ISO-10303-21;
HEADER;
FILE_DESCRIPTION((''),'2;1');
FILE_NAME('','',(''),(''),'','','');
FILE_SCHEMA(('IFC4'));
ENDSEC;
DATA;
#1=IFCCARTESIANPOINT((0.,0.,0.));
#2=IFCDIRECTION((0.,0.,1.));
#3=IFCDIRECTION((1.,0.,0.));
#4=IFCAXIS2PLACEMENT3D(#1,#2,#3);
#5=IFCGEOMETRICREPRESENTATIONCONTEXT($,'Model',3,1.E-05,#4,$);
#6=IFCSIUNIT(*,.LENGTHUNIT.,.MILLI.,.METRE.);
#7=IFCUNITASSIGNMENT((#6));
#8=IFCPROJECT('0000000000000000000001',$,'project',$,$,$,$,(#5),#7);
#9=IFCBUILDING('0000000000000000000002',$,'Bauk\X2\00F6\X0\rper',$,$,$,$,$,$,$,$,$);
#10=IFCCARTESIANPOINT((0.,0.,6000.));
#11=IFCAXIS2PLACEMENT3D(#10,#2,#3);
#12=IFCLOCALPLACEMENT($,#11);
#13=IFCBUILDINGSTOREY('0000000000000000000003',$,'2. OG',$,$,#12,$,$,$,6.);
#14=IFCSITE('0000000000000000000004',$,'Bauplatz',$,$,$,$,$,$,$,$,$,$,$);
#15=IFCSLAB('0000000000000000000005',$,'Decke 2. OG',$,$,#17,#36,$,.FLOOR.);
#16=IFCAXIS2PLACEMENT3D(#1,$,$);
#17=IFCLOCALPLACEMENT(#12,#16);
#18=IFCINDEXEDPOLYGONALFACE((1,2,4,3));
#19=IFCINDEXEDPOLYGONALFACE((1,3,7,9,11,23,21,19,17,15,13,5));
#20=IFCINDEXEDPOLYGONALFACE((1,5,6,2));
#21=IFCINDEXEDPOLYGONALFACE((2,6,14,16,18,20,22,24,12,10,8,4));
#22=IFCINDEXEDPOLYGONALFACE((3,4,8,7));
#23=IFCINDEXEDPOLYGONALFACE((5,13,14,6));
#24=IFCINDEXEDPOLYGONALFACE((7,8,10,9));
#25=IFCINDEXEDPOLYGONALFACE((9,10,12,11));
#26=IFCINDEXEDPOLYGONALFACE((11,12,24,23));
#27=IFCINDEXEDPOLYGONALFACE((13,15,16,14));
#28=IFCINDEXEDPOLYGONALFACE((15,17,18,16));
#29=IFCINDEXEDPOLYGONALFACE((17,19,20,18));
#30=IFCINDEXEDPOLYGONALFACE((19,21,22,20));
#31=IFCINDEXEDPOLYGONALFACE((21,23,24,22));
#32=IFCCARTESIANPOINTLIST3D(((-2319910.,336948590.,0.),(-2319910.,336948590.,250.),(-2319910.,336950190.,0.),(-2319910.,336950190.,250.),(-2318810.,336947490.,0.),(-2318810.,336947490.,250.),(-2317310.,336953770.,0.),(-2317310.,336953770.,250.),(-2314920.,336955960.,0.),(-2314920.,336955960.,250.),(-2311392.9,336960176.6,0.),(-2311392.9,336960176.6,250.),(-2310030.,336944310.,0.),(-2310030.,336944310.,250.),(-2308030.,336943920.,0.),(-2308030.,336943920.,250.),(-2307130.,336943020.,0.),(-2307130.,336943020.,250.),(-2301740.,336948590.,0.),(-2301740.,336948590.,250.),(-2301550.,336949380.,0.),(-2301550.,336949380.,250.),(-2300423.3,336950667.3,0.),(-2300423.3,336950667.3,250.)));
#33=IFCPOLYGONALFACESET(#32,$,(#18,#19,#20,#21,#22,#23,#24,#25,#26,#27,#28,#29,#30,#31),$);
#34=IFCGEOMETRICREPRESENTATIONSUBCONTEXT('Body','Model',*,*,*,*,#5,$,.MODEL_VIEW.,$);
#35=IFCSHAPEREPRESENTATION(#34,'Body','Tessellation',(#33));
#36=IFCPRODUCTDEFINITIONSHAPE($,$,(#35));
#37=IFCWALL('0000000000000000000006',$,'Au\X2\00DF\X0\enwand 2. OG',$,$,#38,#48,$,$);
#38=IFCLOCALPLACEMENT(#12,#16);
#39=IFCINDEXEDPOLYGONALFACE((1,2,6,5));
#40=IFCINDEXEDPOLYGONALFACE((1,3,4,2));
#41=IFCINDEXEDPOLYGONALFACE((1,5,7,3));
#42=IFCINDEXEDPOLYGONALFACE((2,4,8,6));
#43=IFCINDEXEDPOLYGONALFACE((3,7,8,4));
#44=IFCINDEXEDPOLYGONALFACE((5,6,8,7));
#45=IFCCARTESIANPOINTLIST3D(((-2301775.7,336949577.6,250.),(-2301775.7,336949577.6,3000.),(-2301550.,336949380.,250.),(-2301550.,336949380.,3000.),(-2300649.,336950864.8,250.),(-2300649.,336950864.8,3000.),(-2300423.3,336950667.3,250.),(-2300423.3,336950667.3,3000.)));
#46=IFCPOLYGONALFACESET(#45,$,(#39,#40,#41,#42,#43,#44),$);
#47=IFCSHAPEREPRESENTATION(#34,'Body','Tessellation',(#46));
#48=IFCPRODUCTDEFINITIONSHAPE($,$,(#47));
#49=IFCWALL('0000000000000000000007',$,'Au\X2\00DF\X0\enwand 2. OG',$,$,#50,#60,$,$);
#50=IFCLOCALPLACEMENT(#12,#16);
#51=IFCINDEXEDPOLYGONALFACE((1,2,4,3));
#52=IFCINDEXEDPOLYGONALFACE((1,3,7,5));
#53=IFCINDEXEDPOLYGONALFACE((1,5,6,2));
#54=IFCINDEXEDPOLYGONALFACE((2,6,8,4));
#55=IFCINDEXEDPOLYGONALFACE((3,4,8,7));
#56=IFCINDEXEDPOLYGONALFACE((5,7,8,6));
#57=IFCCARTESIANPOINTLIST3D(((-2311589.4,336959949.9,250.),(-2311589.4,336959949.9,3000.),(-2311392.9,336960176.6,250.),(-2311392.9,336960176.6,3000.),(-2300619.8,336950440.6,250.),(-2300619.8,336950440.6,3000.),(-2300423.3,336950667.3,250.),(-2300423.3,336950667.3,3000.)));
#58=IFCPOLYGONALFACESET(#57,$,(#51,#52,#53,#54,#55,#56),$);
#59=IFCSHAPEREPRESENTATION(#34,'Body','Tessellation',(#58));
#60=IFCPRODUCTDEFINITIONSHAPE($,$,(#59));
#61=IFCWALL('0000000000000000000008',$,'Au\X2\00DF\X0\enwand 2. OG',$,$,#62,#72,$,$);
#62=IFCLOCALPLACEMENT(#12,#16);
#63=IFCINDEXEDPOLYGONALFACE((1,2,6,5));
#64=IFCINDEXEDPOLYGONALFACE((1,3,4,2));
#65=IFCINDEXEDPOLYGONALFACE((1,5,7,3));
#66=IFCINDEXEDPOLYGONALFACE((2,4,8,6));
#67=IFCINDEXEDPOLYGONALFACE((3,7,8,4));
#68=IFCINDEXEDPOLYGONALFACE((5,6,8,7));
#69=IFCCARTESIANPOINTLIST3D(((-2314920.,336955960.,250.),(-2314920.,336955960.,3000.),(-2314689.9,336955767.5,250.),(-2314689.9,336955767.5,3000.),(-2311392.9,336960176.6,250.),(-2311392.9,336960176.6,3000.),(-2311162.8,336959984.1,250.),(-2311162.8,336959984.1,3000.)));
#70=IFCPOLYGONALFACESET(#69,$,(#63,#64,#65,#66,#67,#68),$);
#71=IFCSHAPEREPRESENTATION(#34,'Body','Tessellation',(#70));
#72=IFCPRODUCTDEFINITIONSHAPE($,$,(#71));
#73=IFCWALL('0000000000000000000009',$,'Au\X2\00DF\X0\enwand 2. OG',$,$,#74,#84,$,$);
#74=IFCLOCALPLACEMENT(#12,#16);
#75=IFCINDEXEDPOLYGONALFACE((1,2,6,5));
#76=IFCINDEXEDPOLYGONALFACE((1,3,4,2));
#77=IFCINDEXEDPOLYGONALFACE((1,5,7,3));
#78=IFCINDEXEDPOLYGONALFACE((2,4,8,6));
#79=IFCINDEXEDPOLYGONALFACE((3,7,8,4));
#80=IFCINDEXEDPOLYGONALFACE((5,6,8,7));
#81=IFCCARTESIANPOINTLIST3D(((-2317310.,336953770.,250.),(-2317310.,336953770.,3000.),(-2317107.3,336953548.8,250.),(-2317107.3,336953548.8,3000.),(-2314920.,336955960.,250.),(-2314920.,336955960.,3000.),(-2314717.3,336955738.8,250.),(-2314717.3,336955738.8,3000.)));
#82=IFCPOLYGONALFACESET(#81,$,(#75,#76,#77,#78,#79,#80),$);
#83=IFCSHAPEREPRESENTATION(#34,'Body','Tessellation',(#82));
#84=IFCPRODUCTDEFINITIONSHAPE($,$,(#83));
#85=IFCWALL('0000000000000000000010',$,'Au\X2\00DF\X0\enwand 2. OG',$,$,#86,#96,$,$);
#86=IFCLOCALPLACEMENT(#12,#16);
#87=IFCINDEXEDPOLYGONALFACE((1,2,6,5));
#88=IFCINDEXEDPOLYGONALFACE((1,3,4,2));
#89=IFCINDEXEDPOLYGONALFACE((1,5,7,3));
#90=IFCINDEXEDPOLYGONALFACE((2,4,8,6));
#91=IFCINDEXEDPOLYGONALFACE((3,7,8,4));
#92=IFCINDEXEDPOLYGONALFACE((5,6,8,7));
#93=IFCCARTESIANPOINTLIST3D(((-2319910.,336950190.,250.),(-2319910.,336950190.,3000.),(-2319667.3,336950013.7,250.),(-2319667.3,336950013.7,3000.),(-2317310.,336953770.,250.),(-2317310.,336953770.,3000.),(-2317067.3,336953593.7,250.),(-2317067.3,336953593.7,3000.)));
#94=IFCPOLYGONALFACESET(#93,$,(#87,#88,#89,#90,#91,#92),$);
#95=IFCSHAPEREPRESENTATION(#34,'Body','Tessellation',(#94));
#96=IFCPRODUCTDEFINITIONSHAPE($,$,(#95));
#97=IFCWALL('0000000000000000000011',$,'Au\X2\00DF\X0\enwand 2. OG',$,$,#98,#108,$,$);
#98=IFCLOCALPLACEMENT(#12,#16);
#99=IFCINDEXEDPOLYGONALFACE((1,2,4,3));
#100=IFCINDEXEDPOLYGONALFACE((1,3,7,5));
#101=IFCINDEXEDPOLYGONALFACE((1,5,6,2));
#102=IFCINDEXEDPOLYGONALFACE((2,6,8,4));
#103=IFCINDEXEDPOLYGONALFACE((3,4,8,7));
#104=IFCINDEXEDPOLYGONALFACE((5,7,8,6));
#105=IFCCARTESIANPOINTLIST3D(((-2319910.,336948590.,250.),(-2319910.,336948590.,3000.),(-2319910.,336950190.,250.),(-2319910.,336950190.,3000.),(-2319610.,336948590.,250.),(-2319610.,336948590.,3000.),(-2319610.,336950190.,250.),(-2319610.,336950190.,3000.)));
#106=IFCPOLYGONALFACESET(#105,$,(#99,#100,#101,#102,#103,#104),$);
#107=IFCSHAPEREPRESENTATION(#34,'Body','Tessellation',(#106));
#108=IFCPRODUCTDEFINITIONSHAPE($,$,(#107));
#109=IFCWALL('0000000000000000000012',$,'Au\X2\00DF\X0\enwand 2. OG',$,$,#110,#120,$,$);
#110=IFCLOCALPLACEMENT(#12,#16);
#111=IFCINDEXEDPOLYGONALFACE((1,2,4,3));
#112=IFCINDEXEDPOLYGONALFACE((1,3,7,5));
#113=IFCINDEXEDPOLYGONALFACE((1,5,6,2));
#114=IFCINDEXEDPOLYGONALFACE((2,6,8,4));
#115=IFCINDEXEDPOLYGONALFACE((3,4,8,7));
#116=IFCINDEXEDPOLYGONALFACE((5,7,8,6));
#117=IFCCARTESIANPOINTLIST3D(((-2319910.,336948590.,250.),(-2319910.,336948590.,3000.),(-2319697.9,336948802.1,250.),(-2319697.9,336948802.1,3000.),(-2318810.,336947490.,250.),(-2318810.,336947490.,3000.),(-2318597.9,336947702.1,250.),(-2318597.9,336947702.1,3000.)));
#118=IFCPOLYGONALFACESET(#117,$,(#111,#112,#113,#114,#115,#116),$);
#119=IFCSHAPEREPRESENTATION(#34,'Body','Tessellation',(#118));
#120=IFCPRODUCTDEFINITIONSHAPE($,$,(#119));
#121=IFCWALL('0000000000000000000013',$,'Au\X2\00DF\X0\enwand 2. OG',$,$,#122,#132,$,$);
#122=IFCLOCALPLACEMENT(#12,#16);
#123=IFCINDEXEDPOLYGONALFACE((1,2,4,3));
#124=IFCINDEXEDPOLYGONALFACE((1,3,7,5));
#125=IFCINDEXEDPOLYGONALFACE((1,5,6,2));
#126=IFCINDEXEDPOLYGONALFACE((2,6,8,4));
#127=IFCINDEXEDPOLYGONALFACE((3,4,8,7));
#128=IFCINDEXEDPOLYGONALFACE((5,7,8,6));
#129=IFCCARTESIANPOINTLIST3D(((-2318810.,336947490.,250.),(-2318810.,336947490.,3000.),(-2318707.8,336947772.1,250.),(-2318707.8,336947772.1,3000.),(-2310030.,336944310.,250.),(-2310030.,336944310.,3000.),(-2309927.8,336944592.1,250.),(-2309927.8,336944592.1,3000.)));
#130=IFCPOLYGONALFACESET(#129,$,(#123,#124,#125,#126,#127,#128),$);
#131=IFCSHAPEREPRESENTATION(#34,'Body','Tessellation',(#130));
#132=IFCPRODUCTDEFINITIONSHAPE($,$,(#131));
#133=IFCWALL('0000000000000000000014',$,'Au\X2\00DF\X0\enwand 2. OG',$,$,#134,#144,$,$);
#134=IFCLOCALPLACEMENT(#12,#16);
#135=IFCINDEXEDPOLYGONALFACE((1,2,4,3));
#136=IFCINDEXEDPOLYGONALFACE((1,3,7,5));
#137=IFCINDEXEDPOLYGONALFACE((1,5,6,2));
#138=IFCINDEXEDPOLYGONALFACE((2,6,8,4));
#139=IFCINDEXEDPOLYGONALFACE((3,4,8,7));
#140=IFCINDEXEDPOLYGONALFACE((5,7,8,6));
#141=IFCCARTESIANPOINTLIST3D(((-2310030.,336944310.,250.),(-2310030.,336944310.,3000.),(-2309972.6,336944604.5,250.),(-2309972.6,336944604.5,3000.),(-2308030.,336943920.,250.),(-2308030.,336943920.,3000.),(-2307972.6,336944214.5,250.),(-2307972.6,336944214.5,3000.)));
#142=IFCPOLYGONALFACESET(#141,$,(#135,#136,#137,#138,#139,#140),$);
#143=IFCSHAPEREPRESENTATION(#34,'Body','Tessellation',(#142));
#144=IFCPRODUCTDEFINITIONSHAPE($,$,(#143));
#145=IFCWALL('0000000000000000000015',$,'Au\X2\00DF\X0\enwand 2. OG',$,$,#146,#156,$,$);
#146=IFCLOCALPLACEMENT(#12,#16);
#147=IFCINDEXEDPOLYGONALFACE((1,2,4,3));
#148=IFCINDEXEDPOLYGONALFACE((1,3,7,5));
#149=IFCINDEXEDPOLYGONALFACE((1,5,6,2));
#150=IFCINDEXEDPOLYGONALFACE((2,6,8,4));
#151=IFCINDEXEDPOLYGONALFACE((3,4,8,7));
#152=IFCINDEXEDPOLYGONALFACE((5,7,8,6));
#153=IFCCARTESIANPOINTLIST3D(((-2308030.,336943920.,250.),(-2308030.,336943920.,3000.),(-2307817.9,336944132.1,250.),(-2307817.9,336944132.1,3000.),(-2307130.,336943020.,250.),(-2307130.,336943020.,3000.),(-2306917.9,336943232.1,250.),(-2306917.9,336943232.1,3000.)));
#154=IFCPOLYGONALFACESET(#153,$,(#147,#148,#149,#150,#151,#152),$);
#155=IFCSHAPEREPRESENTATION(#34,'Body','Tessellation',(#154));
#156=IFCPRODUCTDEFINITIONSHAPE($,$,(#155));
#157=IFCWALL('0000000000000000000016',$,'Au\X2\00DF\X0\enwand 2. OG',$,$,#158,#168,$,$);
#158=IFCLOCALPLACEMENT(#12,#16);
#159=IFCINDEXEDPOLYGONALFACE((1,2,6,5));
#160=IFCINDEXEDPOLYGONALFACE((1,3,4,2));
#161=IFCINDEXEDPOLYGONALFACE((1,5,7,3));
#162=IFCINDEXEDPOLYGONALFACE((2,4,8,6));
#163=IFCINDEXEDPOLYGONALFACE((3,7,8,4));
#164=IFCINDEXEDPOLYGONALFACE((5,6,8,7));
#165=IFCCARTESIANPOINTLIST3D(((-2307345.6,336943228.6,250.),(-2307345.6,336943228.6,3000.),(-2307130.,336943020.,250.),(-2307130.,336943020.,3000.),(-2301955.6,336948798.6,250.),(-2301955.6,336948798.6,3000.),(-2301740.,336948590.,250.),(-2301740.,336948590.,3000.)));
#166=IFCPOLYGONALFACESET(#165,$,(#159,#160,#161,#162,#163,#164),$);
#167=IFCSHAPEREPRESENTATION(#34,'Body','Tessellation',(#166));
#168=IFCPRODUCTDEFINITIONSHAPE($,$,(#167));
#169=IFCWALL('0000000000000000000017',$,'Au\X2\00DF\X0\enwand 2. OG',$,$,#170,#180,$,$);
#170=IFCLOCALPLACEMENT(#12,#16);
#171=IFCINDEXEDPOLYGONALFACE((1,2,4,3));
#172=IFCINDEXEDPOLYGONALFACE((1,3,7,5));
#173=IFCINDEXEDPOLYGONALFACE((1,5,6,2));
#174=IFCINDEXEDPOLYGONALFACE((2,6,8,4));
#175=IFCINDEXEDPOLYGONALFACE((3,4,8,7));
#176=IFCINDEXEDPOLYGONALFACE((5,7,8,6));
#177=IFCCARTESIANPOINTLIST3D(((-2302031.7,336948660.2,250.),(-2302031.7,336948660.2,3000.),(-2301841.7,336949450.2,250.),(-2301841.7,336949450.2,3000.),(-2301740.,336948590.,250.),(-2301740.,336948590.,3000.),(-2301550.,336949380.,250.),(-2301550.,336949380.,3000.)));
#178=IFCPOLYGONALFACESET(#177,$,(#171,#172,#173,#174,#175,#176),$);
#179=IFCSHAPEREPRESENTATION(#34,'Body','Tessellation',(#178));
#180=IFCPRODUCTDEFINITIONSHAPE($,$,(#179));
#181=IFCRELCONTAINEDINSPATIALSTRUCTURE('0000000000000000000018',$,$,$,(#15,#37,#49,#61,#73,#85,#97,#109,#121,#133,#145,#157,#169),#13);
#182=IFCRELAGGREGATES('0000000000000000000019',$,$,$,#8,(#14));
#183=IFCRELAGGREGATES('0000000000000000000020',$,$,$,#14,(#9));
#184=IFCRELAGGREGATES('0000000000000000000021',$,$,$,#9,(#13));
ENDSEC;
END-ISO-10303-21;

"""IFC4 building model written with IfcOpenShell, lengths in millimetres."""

from ifc_helpers import new_model, si_unit, frame, origin_with_axes, place, context, subcontext, project, spatial, indexed_curve, outline, extrude, element, save


model = new_model("IFC4")

# Units and contexts
model_context = context("Model", 3, precision=1e-05, world=origin_with_axes())
body_context = subcontext(model_context, "Body", "Model", "MODEL_VIEW")
ifc_project = project(units=[si_unit("LENGTHUNIT", "METRE", prefix="MILLI")], contexts=[model_context])

# Site, building, storey
site = spatial("IfcSite", under=ifc_project, Name="Bauplatz")
building = spatial("IfcBuilding", under=site, Name="Baukörper")
storey_placement = place(None, frame((0.0, 0.0, 6000.0), z_axis=(0.0, 0.0, 1.0), x_axis=(1.0, 0.0, 0.0)))
storey = spatial("IfcBuildingStorey", under=building, at=storey_placement, Name="2. OG", Elevation=6.0)

# Slab
slab_placement = place(storey_placement, origin_with_axes())
element("IfcSlab", 1, at=slab_placement, inside=storey, Name="Decke 2. OG", PredefinedType="FLOOR", context=body_context, shape_type="SweptSolid", body=[
    extrude(outline(indexed_curve([(-2301550.0, 336949380.0), (-2301740.0, 336948590.0), (-2307130.0, 336943020.0), (-2308030.0, 336943920.0), (-2310030.0, 336944310.0), (-2318810.0, 336947490.0), (-2319910.0, 336948590.0), (-2319910.0, 336950190.0), (-2317310.0, 336953770.0), (-2314920.0, 336955960.0), (-2311392.9, 336960176.6), (-2300423.3, 336950667.3)])), None, (0.0, 0.0, 1.0), 250.0),
])

# Walls
wall_1_placement = place(storey_placement, frame((-2301550.0, 336949380.0, 250.0), z_axis=(0.0, 0.0, 1.0), x_axis=(0.658621, 0.752475, 0.0)))
element("IfcWall", 2, at=wall_1_placement, inside=storey, Name="Außenwand 2. OG", context=body_context, shape_type="SweptSolid", body=[
    extrude(outline(indexed_curve([(0.0, 0.0), (0.0, 300.0), (1710.7, 300.0), (1710.7, 0.0), (0.0, 0.0)], self_intersect=False)), origin_with_axes(), (0.0, 0.0, 1.0), 2750.0),
])
wall_2_placement = place(storey_placement, frame((-2300423.3, 336950667.3, 250.0), z_axis=(0.0, 0.0, 1.0), x_axis=(-0.75561, 0.655022, 0.0)))
element("IfcWall", 3, at=wall_2_placement, inside=storey, Name="Außenwand 2. OG", context=body_context, shape_type="SweptSolid", body=[
    extrude(outline(indexed_curve([(0.0, 0.0), (0.0, 300.0), (14517.6, 300.0), (14517.6, 0.0), (0.0, 0.0)], self_intersect=False)), origin_with_axes(), (0.0, 0.0, 1.0), 2750.0),
])
wall_3_placement = place(storey_placement, frame((-2311392.9, 336960176.6, 250.0), z_axis=(0.0, 0.0, 1.0), x_axis=(-0.641607, -0.767034, 0.0)))
element("IfcWall", 4, at=wall_3_placement, inside=storey, Name="Außenwand 2. OG", context=body_context, shape_type="SweptSolid", body=[
    extrude(outline(indexed_curve([(0.0, 0.0), (0.0, 300.0), (5497.3, 300.0), (5497.3, 0.0), (0.0, 0.0)], self_intersect=False)), origin_with_axes(), (0.0, 0.0, 1.0), 2750.0),
])
wall_4_placement = place(storey_placement, frame((-2314920.0, 336955960.0, 250.0), z_axis=(0.0, 0.0, 1.0), x_axis=(-0.737282, -0.675585, 0.0)))
element("IfcWall", 5, at=wall_4_placement, inside=storey, Name="Außenwand 2. OG", context=body_context, shape_type="SweptSolid", body=[
    extrude(outline(indexed_curve([(0.0, 0.0), (0.0, 300.0), (3241.6, 300.0), (3241.6, 0.0), (0.0, 0.0)], self_intersect=False)), origin_with_axes(), (0.0, 0.0, 1.0), 2750.0),
])
wall_5_placement = place(storey_placement, frame((-2317310.0, 336953770.0, 250.0), z_axis=(0.0, 0.0, 1.0), x_axis=(-0.587634, -0.809127, 0.0)))
element("IfcWall", 6, at=wall_5_placement, inside=storey, Name="Außenwand 2. OG", context=body_context, shape_type="SweptSolid", body=[
    extrude(outline(indexed_curve([(0.0, 0.0), (0.0, 300.0), (4424.5, 300.0), (4424.5, 0.0), (0.0, 0.0)], self_intersect=False)), origin_with_axes(), (0.0, 0.0, 1.0), 2750.0),
])
wall_6_placement = place(storey_placement, frame((-2319910.0, 336950190.0, 250.0), z_axis=(0.0, 0.0, 1.0), x_axis=(0.0, -1.0, 0.0)))
element("IfcWall", 7, at=wall_6_placement, inside=storey, Name="Außenwand 2. OG", context=body_context, shape_type="SweptSolid", body=[
    extrude(outline(indexed_curve([(0.0, 0.0), (0.0, 300.0), (1600.0, 300.0), (1600.0, 0.0), (0.0, 0.0)], self_intersect=False)), origin_with_axes(), (0.0, 0.0, 1.0), 2750.0),
])
wall_7_placement = place(storey_placement, frame((-2319910.0, 336948590.0, 250.0), z_axis=(0.0, 0.0, 1.0), x_axis=(0.707107, -0.707107, 0.0)))
element("IfcWall", 8, at=wall_7_placement, inside=storey, Name="Außenwand 2. OG", context=body_context, shape_type="SweptSolid", body=[
    extrude(outline(indexed_curve([(0.0, 0.0), (0.0, 300.0), (1555.6, 300.0), (1555.6, 0.0), (0.0, 0.0)], self_intersect=False)), origin_with_axes(), (0.0, 0.0, 1.0), 2750.0),
])
wall_8_placement = place(storey_placement, frame((-2318810.0, 336947490.0, 250.0), z_axis=(0.0, 0.0, 1.0), x_axis=(0.94023, -0.340539, 0.0)))
element("IfcWall", 9, at=wall_8_placement, inside=storey, Name="Außenwand 2. OG", context=body_context, shape_type="SweptSolid", body=[
    extrude(outline(indexed_curve([(0.0, 0.0), (0.0, 300.0), (9338.1, 300.0), (9338.1, 0.0), (0.0, 0.0)], self_intersect=False)), origin_with_axes(), (0.0, 0.0, 1.0), 2750.0),
])
wall_9_placement = place(storey_placement, frame((-2310030.0, 336944310.0, 250.0), z_axis=(0.0, 0.0, 1.0), x_axis=(0.981513, -0.191395, 0.0)))
element("IfcWall", 10, at=wall_9_placement, inside=storey, Name="Außenwand 2. OG", context=body_context, shape_type="SweptSolid", body=[
    extrude(outline(indexed_curve([(0.0, 0.0), (0.0, 300.0), (2037.7, 300.0), (2037.7, 0.0), (0.0, 0.0)], self_intersect=False)), origin_with_axes(), (0.0, 0.0, 1.0), 2750.0),
])
wall_10_placement = place(storey_placement, frame((-2308030.0, 336943920.0, 250.0), z_axis=(0.0, 0.0, 1.0), x_axis=(0.707107, -0.707107, 0.0)))
element("IfcWall", 11, at=wall_10_placement, inside=storey, Name="Außenwand 2. OG", context=body_context, shape_type="SweptSolid", body=[
    extrude(outline(indexed_curve([(0.0, 0.0), (0.0, 300.0), (1272.8, 300.0), (1272.8, 0.0), (0.0, 0.0)], self_intersect=False)), origin_with_axes(), (0.0, 0.0, 1.0), 2750.0),
])
wall_11_placement = place(storey_placement, frame((-2307130.0, 336943020.0, 250.0), z_axis=(0.0, 0.0, 1.0), x_axis=(0.6954, 0.718623, 0.0)))
element("IfcWall", 12, at=wall_11_placement, inside=storey, Name="Außenwand 2. OG", context=body_context, shape_type="SweptSolid", body=[
    extrude(outline(indexed_curve([(0.0, 0.0), (0.0, 300.0), (7750.9, 300.0), (7750.9, 0.0), (0.0, 0.0)], self_intersect=False)), origin_with_axes(), (0.0, 0.0, 1.0), 2750.0),
])
wall_12_placement = place(storey_placement, frame((-2301740.0, 336948590.0, 250.0), z_axis=(0.0, 0.0, 1.0), x_axis=(0.233838, 0.972275, 0.0)))
element("IfcWall", 13, at=wall_12_placement, inside=storey, Name="Außenwand 2. OG", context=body_context, shape_type="SweptSolid", body=[
    extrude(outline(indexed_curve([(0.0, 0.0), (0.0, 300.0), (812.5, 300.0), (812.5, 0.0), (0.0, 0.0)], self_intersect=False)), origin_with_axes(), (0.0, 0.0, 1.0), 2750.0),
])

save(model, "model.ifc")
